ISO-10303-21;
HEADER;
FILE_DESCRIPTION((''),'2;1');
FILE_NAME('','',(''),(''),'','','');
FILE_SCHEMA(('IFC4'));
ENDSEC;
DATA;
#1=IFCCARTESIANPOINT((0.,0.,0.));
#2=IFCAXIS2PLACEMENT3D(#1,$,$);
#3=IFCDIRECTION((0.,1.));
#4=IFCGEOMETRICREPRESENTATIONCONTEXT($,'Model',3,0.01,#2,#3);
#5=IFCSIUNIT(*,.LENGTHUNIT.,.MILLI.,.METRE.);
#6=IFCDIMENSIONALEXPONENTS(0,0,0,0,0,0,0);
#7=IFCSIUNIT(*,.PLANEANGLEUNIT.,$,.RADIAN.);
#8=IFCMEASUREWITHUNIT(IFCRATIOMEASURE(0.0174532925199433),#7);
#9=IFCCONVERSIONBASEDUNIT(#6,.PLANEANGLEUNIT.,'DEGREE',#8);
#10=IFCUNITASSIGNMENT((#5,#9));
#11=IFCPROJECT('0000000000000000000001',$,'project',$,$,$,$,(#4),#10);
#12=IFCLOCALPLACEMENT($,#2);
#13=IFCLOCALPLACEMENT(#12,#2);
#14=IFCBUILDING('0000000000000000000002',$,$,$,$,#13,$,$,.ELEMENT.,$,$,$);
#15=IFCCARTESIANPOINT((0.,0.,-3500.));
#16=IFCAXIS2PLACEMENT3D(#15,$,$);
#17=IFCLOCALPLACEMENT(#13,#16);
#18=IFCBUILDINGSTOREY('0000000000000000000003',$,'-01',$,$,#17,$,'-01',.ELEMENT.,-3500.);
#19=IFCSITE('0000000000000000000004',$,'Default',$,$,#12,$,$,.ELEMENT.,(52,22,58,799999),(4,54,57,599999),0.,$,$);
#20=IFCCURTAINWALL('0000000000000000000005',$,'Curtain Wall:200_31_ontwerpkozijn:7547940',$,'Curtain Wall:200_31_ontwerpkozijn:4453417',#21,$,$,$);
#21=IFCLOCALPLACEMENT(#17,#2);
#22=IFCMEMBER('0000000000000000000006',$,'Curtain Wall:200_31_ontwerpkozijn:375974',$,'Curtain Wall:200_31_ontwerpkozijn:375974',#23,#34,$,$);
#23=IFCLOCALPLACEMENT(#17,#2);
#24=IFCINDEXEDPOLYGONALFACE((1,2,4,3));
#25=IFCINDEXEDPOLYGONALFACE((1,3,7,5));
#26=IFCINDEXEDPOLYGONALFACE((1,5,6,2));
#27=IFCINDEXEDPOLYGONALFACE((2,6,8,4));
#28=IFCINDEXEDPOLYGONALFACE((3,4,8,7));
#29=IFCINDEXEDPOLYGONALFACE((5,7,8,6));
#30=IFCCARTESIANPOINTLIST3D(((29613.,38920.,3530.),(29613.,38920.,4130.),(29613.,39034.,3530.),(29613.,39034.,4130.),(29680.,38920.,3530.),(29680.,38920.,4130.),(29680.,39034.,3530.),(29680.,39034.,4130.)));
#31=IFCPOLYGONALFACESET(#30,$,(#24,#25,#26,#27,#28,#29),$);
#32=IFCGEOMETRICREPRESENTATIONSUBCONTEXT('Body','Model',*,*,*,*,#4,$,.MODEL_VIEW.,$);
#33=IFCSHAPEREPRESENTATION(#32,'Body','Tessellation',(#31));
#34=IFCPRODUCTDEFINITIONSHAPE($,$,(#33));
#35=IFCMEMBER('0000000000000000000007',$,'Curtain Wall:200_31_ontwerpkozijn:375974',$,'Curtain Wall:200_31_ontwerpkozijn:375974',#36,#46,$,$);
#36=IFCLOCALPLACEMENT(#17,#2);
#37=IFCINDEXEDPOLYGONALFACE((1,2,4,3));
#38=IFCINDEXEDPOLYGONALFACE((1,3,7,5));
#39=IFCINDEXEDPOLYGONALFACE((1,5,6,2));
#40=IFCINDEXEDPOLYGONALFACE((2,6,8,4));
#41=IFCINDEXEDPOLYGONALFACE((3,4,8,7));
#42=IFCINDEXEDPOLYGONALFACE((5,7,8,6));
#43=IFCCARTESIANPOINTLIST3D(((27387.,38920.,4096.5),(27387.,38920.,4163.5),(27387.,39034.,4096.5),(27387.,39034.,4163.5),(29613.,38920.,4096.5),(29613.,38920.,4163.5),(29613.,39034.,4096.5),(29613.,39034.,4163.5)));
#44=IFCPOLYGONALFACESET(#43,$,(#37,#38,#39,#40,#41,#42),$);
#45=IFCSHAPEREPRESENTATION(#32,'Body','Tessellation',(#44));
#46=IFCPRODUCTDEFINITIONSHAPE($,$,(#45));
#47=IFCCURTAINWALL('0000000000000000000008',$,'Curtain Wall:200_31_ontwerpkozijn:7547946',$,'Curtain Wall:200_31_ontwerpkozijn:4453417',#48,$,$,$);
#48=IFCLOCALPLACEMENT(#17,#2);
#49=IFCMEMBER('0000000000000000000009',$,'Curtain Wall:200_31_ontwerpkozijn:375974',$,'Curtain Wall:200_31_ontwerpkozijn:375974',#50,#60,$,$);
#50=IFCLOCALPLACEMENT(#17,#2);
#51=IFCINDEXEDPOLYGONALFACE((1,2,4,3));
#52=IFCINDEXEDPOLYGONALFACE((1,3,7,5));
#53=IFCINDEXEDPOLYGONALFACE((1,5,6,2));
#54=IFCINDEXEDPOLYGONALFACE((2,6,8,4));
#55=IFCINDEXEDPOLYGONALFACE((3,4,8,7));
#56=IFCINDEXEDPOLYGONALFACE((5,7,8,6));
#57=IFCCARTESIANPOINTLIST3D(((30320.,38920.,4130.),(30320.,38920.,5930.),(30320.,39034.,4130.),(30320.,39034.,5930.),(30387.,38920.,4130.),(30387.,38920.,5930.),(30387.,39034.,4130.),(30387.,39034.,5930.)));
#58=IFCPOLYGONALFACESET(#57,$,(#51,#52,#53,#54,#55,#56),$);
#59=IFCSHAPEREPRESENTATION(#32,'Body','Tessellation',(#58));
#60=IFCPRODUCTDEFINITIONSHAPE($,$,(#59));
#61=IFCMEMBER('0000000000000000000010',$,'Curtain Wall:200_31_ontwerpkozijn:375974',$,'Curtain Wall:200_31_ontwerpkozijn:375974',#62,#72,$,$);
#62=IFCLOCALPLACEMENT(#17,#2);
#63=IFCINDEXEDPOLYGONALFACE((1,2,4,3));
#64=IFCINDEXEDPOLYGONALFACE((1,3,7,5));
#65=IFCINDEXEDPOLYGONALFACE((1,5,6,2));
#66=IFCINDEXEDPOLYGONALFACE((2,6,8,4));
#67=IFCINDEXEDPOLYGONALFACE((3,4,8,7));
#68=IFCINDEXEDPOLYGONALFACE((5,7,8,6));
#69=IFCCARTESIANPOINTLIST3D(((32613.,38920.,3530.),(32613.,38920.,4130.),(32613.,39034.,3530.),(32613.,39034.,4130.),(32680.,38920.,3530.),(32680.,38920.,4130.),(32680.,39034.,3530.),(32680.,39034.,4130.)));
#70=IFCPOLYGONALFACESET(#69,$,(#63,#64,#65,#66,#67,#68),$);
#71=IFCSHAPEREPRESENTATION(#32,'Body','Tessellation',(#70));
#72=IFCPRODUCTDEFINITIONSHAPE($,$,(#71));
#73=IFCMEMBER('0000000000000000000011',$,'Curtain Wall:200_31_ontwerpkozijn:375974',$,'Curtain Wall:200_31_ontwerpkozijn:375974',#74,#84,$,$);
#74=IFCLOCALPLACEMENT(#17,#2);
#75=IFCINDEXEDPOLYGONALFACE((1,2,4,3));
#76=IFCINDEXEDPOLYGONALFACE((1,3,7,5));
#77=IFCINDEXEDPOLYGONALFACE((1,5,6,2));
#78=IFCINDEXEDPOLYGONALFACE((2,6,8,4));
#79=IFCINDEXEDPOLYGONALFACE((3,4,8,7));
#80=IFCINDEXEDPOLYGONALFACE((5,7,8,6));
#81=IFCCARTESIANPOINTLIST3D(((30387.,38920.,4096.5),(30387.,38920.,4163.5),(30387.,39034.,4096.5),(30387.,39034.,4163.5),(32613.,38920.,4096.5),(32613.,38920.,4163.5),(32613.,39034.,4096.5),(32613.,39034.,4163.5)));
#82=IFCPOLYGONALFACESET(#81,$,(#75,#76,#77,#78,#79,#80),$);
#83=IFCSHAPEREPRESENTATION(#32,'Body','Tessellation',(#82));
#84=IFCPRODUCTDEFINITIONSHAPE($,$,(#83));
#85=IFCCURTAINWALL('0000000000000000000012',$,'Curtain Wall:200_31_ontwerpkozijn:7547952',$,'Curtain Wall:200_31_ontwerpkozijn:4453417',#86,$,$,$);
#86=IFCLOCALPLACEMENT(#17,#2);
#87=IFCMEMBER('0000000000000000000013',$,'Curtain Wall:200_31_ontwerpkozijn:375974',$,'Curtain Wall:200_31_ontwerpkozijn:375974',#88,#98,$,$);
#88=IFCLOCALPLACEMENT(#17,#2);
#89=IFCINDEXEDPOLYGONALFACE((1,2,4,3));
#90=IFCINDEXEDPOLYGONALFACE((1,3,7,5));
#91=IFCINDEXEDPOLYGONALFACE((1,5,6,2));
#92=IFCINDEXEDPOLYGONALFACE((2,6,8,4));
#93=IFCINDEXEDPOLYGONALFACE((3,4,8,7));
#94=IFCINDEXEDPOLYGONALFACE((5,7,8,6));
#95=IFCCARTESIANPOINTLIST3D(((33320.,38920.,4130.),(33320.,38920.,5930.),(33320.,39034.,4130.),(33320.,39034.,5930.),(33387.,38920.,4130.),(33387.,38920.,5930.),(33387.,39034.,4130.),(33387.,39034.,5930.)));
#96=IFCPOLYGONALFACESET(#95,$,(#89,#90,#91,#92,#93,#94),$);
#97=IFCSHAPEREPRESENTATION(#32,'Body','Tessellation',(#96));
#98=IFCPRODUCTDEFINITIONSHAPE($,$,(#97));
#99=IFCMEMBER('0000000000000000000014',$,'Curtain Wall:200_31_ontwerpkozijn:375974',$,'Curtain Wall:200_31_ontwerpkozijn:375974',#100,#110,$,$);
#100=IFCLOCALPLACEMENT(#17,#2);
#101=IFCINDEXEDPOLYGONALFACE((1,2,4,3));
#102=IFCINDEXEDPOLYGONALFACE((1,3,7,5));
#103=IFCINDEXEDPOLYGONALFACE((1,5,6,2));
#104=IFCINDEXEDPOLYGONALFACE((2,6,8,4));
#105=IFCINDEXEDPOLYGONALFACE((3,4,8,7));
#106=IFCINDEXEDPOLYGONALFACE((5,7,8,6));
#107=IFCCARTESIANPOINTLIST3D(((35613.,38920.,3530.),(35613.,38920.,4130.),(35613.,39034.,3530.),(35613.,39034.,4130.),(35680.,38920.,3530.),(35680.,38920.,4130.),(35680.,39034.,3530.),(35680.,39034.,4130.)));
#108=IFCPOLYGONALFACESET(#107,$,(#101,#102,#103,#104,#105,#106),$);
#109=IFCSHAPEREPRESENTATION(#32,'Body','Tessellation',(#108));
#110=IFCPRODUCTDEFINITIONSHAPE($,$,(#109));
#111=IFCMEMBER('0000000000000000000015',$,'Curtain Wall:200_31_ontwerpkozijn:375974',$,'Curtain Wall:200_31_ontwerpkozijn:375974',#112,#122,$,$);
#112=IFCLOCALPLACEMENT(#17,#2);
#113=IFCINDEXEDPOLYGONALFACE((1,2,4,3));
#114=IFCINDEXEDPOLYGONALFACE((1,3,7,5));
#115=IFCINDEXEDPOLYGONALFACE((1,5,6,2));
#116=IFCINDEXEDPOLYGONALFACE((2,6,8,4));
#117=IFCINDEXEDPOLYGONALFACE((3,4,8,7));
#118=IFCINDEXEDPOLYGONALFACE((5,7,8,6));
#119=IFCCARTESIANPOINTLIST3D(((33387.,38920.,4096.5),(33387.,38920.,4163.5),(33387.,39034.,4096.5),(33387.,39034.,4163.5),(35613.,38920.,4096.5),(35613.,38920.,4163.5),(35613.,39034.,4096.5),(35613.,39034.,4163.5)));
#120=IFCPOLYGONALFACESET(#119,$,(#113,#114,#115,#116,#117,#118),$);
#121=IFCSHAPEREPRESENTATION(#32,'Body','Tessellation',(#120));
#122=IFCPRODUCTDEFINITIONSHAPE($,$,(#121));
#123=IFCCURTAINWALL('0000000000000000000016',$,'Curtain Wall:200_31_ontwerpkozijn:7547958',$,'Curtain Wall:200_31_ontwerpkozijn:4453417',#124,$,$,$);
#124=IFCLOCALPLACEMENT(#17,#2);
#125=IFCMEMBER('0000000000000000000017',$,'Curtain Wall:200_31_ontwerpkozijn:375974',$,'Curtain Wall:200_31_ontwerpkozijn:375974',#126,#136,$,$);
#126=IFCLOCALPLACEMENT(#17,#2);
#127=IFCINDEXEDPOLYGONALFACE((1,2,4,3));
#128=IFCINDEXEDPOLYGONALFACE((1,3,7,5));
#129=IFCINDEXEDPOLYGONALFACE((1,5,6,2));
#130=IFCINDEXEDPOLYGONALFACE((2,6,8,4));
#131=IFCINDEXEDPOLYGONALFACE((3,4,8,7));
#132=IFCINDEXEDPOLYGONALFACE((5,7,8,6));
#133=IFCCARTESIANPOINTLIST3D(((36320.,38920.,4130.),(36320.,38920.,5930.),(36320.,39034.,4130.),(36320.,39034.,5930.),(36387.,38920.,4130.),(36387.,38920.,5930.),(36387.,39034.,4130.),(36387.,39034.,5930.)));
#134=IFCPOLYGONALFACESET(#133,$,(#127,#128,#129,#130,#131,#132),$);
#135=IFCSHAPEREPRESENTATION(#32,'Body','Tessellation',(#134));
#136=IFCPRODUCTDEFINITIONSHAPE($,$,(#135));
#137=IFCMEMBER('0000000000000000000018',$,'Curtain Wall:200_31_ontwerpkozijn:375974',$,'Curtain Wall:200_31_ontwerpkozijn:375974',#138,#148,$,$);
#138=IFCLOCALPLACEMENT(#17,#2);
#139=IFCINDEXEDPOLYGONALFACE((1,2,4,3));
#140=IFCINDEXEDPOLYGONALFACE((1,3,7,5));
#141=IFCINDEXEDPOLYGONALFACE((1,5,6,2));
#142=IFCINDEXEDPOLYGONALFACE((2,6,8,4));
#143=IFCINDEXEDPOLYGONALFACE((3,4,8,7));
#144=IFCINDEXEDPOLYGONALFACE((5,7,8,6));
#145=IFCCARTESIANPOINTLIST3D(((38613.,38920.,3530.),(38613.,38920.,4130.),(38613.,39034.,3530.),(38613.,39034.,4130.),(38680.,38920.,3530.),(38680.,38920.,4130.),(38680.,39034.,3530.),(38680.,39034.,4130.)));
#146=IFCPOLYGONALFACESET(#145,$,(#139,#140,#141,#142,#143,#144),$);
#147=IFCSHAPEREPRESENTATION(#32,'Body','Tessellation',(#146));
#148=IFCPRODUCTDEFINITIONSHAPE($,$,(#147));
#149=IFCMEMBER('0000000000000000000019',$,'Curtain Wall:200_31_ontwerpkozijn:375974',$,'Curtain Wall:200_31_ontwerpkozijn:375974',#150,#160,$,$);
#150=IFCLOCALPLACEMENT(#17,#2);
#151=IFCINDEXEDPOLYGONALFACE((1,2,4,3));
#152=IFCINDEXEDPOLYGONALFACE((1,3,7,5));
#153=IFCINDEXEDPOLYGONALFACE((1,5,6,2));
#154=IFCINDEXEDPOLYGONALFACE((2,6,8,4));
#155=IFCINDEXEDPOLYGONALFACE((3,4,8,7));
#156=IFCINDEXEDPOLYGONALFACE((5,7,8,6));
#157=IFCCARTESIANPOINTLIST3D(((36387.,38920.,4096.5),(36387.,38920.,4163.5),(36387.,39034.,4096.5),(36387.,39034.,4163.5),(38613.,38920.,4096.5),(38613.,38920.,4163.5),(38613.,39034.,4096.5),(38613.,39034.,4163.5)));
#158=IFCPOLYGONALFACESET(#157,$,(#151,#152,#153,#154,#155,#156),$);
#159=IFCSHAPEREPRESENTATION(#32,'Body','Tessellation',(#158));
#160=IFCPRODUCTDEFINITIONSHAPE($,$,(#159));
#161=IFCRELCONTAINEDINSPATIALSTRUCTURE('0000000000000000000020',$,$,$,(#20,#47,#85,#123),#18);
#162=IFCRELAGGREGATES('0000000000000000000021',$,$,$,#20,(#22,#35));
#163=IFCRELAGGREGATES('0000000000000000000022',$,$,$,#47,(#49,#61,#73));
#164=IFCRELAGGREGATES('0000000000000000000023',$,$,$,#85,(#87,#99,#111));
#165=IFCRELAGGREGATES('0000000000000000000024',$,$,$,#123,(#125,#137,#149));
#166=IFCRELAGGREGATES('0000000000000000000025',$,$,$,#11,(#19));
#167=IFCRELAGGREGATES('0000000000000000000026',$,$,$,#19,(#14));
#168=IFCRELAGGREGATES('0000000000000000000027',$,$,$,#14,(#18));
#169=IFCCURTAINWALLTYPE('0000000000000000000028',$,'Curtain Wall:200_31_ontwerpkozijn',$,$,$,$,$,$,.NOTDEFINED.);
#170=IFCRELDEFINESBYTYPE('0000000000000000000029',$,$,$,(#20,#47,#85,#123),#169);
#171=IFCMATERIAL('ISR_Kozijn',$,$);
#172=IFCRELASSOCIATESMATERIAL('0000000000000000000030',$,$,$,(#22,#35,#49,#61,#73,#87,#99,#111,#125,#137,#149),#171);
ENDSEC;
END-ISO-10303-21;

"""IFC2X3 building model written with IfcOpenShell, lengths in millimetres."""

from ifc_helpers import new_model, entity, si_unit, converted_unit, direction, frame, frame_2d, origin, place, context, subcontext, project, spatial, rectangle, extrude, material, type_object, element, aggregate, save


model = new_model("IFC2X3")

# Units and contexts
model_context = context("Model", 3, precision=0.01, world=origin(), true_north=direction((0.0, 1.0)))
body_context = subcontext(model_context, "Body", "Model", "MODEL_VIEW")
ifc_project = project(units=[si_unit("LENGTHUNIT", "METRE", prefix="MILLI"), converted_unit("PLANEANGLEUNIT", "DEGREE", entity("IfcRatioMeasure", 0.0174532925199433), si_unit("PLANEANGLEUNIT", "RADIAN"), dimensions=[0, 0, 0, 0, 0, 0, 0])], contexts=[model_context])

# Site, building, storey
site_placement = place(None, origin())
site = spatial("IfcSite", under=ifc_project, at=site_placement, Name="Default", CompositionType="ELEMENT", RefLatitude=(52, 22, 58, 799999), RefLongitude=(4, 54, 57, 599999), RefElevation=0.0)
building_placement = place(site_placement, origin())
building = spatial("IfcBuilding", under=site, at=building_placement, CompositionType="ELEMENT")
storey_placement = place(building_placement, frame((0.0, 0.0, -3500.0)))
storey = spatial("IfcBuildingStorey", under=building, at=storey_placement, Name="-01", LongName="-01", CompositionType="ELEMENT", Elevation=-3500.0)

# Curtain walls, members
curtain_wall_type = type_object("IfcCurtainWallType", Name="Curtain Wall:200_31_ontwerpkozijn", PredefinedType="NOTDEFINED")
curtain_wall_1_placement = place(storey_placement, frame((0.0, 0.0, 3500.0)))
curtain_wall_1 = element("IfcCurtainWall", 1, at=curtain_wall_1_placement, inside=storey, type_object=curtain_wall_type, Name="Curtain Wall:200_31_ontwerpkozijn:7547940", ObjectType="Curtain Wall:200_31_ontwerpkozijn:4453417")
ifc_material = material(Name="ISR_Kozijn")
member_1_placement = place(curtain_wall_1_placement, frame((0.0, 0.0, -3500.0)))
member_1 = element("IfcMember", 2, at=member_1_placement, material=ifc_material, Name="Curtain Wall:200_31_ontwerpkozijn:375974", ObjectType="Curtain Wall:200_31_ontwerpkozijn:375974", context=body_context, shape_type="SweptSolid", body=[
    extrude(rectangle(XDim=67.0, YDim=114.0, at=frame_2d((0.0, 0.0), x_axis=(1.0, 0.0))), frame((29646.5, 38977.0, 4130.0), z_axis=(0.0, 0.0, -1.0), x_axis=(-1.0, 0.0, 0.0)), (0.0, 0.0, 1.0), 600.0),
])
member_2_placement = place(curtain_wall_1_placement, frame((0.0, 0.0, -3500.0)))
member_2 = element("IfcMember", 3, at=member_2_placement, material=ifc_material, Name="Curtain Wall:200_31_ontwerpkozijn:375974", ObjectType="Curtain Wall:200_31_ontwerpkozijn:375974", context=body_context, shape_type="SweptSolid", body=[
    extrude(rectangle(XDim=67.0, YDim=114.0, at=frame_2d((0.0, 0.0), x_axis=(1.0, 0.0))), frame((27387.0, 38977.0, 4130.0), z_axis=(1.0, 0.0, 0.0), x_axis=(0.0, 0.0, -1.0)), (0.0, 0.0, 1.0), 2226.0),
])
aggregate(curtain_wall_1, [member_1, member_2])
curtain_wall_2_placement = place(storey_placement, frame((0.0, 0.0, 3500.0)))
curtain_wall_2 = element("IfcCurtainWall", 4, at=curtain_wall_2_placement, inside=storey, type_object=curtain_wall_type, Name="Curtain Wall:200_31_ontwerpkozijn:7547946", ObjectType="Curtain Wall:200_31_ontwerpkozijn:4453417")
member_3_placement = place(curtain_wall_2_placement, frame((0.0, 0.0, -3500.0)))
member_3 = element("IfcMember", 5, at=member_3_placement, material=ifc_material, Name="Curtain Wall:200_31_ontwerpkozijn:375974", ObjectType="Curtain Wall:200_31_ontwerpkozijn:375974", context=body_context, shape_type="SweptSolid", body=[
    extrude(rectangle(XDim=67.0, YDim=114.0, at=frame_2d((0.0, 0.0), x_axis=(1.0, 0.0))), frame((30353.5, 38977.0, 4130.0), z_axis=(0.0, 0.0, 1.0), x_axis=(-1.0, 0.0, 0.0)), (0.0, 0.0, 1.0), 1800.0),
])
member_4_placement = place(curtain_wall_2_placement, frame((0.0, 0.0, -3500.0)))
member_4 = element("IfcMember", 6, at=member_4_placement, material=ifc_material, Name="Curtain Wall:200_31_ontwerpkozijn:375974", ObjectType="Curtain Wall:200_31_ontwerpkozijn:375974", context=body_context, shape_type="SweptSolid", body=[
    extrude(rectangle(XDim=67.0, YDim=114.0, at=frame_2d((0.0, 0.0), x_axis=(1.0, 0.0))), frame((32646.5, 38977.0, 4130.0), z_axis=(0.0, 0.0, -1.0), x_axis=(-1.0, 0.0, 0.0)), (0.0, 0.0, 1.0), 600.0),
])
member_5_placement = place(curtain_wall_2_placement, frame((0.0, 0.0, -3500.0)))
member_5 = element("IfcMember", 7, at=member_5_placement, material=ifc_material, Name="Curtain Wall:200_31_ontwerpkozijn:375974", ObjectType="Curtain Wall:200_31_ontwerpkozijn:375974", context=body_context, shape_type="SweptSolid", body=[
    extrude(rectangle(XDim=67.0, YDim=114.0, at=frame_2d((0.0, 0.0), x_axis=(1.0, 0.0))), frame((30387.0, 38977.0, 4130.0), z_axis=(1.0, 0.0, 0.0), x_axis=(0.0, 0.0, -1.0)), (0.0, 0.0, 1.0), 2226.0),
])
aggregate(curtain_wall_2, [member_3, member_4, member_5])
curtain_wall_3_placement = place(storey_placement, frame((0.0, 0.0, 3500.0)))
curtain_wall_3 = element("IfcCurtainWall", 8, at=curtain_wall_3_placement, inside=storey, type_object=curtain_wall_type, Name="Curtain Wall:200_31_ontwerpkozijn:7547952", ObjectType="Curtain Wall:200_31_ontwerpkozijn:4453417")
member_6_placement = place(curtain_wall_3_placement, frame((0.0, 0.0, -3500.0)))
member_6 = element("IfcMember", 9, at=member_6_placement, material=ifc_material, Name="Curtain Wall:200_31_ontwerpkozijn:375974", ObjectType="Curtain Wall:200_31_ontwerpkozijn:375974", context=body_context, shape_type="SweptSolid", body=[
    extrude(rectangle(XDim=67.0, YDim=114.0, at=frame_2d((0.0, 0.0), x_axis=(1.0, 0.0))), frame((33353.5, 38977.0, 4130.0), z_axis=(0.0, 0.0, 1.0), x_axis=(-1.0, 0.0, 0.0)), (0.0, 0.0, 1.0), 1800.0),
])
member_7_placement = place(curtain_wall_3_placement, frame((0.0, 0.0, -3500.0)))
member_7 = element("IfcMember", 10, at=member_7_placement, material=ifc_material, Name="Curtain Wall:200_31_ontwerpkozijn:375974", ObjectType="Curtain Wall:200_31_ontwerpkozijn:375974", context=body_context, shape_type="SweptSolid", body=[
    extrude(rectangle(XDim=67.0, YDim=114.0, at=frame_2d((0.0, 0.0), x_axis=(1.0, 0.0))), frame((35646.5, 38977.0, 4130.0), z_axis=(0.0, 0.0, -1.0), x_axis=(-1.0, 0.0, 0.0)), (0.0, 0.0, 1.0), 600.0),
])
member_8_placement = place(curtain_wall_3_placement, frame((0.0, 0.0, -3500.0)))
member_8 = element("IfcMember", 11, at=member_8_placement, material=ifc_material, Name="Curtain Wall:200_31_ontwerpkozijn:375974", ObjectType="Curtain Wall:200_31_ontwerpkozijn:375974", context=body_context, shape_type="SweptSolid", body=[
    extrude(rectangle(XDim=67.0, YDim=114.0, at=frame_2d((0.0, 0.0), x_axis=(1.0, 0.0))), frame((33387.0, 38977.0, 4130.0), z_axis=(1.0, 0.0, 0.0), x_axis=(0.0, 0.0, -1.0)), (0.0, 0.0, 1.0), 2226.0),
])
aggregate(curtain_wall_3, [member_6, member_7, member_8])
curtain_wall_4_placement = place(storey_placement, frame((0.0, 0.0, 3500.0)))
curtain_wall_4 = element("IfcCurtainWall", 12, at=curtain_wall_4_placement, inside=storey, type_object=curtain_wall_type, Name="Curtain Wall:200_31_ontwerpkozijn:7547958", ObjectType="Curtain Wall:200_31_ontwerpkozijn:4453417")
member_9_placement = place(curtain_wall_4_placement, frame((0.0, 0.0, -3500.0)))
member_9 = element("IfcMember", 13, at=member_9_placement, material=ifc_material, Name="Curtain Wall:200_31_ontwerpkozijn:375974", ObjectType="Curtain Wall:200_31_ontwerpkozijn:375974", context=body_context, shape_type="SweptSolid", body=[
    extrude(rectangle(XDim=67.0, YDim=114.0, at=frame_2d((0.0, 0.0), x_axis=(1.0, 0.0))), frame((36353.5, 38977.0, 4130.0), z_axis=(0.0, 0.0, 1.0), x_axis=(-1.0, 0.0, 0.0)), (0.0, 0.0, 1.0), 1800.0),
])
member_10_placement = place(curtain_wall_4_placement, frame((0.0, 0.0, -3500.0)))
member_10 = element("IfcMember", 14, at=member_10_placement, material=ifc_material, Name="Curtain Wall:200_31_ontwerpkozijn:375974", ObjectType="Curtain Wall:200_31_ontwerpkozijn:375974", context=body_context, shape_type="SweptSolid", body=[
    extrude(rectangle(XDim=67.0, YDim=114.0, at=frame_2d((0.0, 0.0), x_axis=(1.0, 0.0))), frame((38646.5, 38977.0, 4130.0), z_axis=(0.0, 0.0, -1.0), x_axis=(-1.0, 0.0, 0.0)), (0.0, 0.0, 1.0), 600.0),
])
member_11_placement = place(curtain_wall_4_placement, frame((0.0, 0.0, -3500.0)))
member_11 = element("IfcMember", 15, at=member_11_placement, material=ifc_material, Name="Curtain Wall:200_31_ontwerpkozijn:375974", ObjectType="Curtain Wall:200_31_ontwerpkozijn:375974", context=body_context, shape_type="SweptSolid", body=[
    extrude(rectangle(XDim=67.0, YDim=114.0, at=frame_2d((0.0, 0.0), x_axis=(1.0, 0.0))), frame((36387.0, 38977.0, 4130.0), z_axis=(1.0, 0.0, 0.0), x_axis=(0.0, 0.0, -1.0)), (0.0, 0.0, 1.0), 2226.0),
])
aggregate(curtain_wall_4, [member_9, member_10, member_11])

save(model, "model.ifc")
